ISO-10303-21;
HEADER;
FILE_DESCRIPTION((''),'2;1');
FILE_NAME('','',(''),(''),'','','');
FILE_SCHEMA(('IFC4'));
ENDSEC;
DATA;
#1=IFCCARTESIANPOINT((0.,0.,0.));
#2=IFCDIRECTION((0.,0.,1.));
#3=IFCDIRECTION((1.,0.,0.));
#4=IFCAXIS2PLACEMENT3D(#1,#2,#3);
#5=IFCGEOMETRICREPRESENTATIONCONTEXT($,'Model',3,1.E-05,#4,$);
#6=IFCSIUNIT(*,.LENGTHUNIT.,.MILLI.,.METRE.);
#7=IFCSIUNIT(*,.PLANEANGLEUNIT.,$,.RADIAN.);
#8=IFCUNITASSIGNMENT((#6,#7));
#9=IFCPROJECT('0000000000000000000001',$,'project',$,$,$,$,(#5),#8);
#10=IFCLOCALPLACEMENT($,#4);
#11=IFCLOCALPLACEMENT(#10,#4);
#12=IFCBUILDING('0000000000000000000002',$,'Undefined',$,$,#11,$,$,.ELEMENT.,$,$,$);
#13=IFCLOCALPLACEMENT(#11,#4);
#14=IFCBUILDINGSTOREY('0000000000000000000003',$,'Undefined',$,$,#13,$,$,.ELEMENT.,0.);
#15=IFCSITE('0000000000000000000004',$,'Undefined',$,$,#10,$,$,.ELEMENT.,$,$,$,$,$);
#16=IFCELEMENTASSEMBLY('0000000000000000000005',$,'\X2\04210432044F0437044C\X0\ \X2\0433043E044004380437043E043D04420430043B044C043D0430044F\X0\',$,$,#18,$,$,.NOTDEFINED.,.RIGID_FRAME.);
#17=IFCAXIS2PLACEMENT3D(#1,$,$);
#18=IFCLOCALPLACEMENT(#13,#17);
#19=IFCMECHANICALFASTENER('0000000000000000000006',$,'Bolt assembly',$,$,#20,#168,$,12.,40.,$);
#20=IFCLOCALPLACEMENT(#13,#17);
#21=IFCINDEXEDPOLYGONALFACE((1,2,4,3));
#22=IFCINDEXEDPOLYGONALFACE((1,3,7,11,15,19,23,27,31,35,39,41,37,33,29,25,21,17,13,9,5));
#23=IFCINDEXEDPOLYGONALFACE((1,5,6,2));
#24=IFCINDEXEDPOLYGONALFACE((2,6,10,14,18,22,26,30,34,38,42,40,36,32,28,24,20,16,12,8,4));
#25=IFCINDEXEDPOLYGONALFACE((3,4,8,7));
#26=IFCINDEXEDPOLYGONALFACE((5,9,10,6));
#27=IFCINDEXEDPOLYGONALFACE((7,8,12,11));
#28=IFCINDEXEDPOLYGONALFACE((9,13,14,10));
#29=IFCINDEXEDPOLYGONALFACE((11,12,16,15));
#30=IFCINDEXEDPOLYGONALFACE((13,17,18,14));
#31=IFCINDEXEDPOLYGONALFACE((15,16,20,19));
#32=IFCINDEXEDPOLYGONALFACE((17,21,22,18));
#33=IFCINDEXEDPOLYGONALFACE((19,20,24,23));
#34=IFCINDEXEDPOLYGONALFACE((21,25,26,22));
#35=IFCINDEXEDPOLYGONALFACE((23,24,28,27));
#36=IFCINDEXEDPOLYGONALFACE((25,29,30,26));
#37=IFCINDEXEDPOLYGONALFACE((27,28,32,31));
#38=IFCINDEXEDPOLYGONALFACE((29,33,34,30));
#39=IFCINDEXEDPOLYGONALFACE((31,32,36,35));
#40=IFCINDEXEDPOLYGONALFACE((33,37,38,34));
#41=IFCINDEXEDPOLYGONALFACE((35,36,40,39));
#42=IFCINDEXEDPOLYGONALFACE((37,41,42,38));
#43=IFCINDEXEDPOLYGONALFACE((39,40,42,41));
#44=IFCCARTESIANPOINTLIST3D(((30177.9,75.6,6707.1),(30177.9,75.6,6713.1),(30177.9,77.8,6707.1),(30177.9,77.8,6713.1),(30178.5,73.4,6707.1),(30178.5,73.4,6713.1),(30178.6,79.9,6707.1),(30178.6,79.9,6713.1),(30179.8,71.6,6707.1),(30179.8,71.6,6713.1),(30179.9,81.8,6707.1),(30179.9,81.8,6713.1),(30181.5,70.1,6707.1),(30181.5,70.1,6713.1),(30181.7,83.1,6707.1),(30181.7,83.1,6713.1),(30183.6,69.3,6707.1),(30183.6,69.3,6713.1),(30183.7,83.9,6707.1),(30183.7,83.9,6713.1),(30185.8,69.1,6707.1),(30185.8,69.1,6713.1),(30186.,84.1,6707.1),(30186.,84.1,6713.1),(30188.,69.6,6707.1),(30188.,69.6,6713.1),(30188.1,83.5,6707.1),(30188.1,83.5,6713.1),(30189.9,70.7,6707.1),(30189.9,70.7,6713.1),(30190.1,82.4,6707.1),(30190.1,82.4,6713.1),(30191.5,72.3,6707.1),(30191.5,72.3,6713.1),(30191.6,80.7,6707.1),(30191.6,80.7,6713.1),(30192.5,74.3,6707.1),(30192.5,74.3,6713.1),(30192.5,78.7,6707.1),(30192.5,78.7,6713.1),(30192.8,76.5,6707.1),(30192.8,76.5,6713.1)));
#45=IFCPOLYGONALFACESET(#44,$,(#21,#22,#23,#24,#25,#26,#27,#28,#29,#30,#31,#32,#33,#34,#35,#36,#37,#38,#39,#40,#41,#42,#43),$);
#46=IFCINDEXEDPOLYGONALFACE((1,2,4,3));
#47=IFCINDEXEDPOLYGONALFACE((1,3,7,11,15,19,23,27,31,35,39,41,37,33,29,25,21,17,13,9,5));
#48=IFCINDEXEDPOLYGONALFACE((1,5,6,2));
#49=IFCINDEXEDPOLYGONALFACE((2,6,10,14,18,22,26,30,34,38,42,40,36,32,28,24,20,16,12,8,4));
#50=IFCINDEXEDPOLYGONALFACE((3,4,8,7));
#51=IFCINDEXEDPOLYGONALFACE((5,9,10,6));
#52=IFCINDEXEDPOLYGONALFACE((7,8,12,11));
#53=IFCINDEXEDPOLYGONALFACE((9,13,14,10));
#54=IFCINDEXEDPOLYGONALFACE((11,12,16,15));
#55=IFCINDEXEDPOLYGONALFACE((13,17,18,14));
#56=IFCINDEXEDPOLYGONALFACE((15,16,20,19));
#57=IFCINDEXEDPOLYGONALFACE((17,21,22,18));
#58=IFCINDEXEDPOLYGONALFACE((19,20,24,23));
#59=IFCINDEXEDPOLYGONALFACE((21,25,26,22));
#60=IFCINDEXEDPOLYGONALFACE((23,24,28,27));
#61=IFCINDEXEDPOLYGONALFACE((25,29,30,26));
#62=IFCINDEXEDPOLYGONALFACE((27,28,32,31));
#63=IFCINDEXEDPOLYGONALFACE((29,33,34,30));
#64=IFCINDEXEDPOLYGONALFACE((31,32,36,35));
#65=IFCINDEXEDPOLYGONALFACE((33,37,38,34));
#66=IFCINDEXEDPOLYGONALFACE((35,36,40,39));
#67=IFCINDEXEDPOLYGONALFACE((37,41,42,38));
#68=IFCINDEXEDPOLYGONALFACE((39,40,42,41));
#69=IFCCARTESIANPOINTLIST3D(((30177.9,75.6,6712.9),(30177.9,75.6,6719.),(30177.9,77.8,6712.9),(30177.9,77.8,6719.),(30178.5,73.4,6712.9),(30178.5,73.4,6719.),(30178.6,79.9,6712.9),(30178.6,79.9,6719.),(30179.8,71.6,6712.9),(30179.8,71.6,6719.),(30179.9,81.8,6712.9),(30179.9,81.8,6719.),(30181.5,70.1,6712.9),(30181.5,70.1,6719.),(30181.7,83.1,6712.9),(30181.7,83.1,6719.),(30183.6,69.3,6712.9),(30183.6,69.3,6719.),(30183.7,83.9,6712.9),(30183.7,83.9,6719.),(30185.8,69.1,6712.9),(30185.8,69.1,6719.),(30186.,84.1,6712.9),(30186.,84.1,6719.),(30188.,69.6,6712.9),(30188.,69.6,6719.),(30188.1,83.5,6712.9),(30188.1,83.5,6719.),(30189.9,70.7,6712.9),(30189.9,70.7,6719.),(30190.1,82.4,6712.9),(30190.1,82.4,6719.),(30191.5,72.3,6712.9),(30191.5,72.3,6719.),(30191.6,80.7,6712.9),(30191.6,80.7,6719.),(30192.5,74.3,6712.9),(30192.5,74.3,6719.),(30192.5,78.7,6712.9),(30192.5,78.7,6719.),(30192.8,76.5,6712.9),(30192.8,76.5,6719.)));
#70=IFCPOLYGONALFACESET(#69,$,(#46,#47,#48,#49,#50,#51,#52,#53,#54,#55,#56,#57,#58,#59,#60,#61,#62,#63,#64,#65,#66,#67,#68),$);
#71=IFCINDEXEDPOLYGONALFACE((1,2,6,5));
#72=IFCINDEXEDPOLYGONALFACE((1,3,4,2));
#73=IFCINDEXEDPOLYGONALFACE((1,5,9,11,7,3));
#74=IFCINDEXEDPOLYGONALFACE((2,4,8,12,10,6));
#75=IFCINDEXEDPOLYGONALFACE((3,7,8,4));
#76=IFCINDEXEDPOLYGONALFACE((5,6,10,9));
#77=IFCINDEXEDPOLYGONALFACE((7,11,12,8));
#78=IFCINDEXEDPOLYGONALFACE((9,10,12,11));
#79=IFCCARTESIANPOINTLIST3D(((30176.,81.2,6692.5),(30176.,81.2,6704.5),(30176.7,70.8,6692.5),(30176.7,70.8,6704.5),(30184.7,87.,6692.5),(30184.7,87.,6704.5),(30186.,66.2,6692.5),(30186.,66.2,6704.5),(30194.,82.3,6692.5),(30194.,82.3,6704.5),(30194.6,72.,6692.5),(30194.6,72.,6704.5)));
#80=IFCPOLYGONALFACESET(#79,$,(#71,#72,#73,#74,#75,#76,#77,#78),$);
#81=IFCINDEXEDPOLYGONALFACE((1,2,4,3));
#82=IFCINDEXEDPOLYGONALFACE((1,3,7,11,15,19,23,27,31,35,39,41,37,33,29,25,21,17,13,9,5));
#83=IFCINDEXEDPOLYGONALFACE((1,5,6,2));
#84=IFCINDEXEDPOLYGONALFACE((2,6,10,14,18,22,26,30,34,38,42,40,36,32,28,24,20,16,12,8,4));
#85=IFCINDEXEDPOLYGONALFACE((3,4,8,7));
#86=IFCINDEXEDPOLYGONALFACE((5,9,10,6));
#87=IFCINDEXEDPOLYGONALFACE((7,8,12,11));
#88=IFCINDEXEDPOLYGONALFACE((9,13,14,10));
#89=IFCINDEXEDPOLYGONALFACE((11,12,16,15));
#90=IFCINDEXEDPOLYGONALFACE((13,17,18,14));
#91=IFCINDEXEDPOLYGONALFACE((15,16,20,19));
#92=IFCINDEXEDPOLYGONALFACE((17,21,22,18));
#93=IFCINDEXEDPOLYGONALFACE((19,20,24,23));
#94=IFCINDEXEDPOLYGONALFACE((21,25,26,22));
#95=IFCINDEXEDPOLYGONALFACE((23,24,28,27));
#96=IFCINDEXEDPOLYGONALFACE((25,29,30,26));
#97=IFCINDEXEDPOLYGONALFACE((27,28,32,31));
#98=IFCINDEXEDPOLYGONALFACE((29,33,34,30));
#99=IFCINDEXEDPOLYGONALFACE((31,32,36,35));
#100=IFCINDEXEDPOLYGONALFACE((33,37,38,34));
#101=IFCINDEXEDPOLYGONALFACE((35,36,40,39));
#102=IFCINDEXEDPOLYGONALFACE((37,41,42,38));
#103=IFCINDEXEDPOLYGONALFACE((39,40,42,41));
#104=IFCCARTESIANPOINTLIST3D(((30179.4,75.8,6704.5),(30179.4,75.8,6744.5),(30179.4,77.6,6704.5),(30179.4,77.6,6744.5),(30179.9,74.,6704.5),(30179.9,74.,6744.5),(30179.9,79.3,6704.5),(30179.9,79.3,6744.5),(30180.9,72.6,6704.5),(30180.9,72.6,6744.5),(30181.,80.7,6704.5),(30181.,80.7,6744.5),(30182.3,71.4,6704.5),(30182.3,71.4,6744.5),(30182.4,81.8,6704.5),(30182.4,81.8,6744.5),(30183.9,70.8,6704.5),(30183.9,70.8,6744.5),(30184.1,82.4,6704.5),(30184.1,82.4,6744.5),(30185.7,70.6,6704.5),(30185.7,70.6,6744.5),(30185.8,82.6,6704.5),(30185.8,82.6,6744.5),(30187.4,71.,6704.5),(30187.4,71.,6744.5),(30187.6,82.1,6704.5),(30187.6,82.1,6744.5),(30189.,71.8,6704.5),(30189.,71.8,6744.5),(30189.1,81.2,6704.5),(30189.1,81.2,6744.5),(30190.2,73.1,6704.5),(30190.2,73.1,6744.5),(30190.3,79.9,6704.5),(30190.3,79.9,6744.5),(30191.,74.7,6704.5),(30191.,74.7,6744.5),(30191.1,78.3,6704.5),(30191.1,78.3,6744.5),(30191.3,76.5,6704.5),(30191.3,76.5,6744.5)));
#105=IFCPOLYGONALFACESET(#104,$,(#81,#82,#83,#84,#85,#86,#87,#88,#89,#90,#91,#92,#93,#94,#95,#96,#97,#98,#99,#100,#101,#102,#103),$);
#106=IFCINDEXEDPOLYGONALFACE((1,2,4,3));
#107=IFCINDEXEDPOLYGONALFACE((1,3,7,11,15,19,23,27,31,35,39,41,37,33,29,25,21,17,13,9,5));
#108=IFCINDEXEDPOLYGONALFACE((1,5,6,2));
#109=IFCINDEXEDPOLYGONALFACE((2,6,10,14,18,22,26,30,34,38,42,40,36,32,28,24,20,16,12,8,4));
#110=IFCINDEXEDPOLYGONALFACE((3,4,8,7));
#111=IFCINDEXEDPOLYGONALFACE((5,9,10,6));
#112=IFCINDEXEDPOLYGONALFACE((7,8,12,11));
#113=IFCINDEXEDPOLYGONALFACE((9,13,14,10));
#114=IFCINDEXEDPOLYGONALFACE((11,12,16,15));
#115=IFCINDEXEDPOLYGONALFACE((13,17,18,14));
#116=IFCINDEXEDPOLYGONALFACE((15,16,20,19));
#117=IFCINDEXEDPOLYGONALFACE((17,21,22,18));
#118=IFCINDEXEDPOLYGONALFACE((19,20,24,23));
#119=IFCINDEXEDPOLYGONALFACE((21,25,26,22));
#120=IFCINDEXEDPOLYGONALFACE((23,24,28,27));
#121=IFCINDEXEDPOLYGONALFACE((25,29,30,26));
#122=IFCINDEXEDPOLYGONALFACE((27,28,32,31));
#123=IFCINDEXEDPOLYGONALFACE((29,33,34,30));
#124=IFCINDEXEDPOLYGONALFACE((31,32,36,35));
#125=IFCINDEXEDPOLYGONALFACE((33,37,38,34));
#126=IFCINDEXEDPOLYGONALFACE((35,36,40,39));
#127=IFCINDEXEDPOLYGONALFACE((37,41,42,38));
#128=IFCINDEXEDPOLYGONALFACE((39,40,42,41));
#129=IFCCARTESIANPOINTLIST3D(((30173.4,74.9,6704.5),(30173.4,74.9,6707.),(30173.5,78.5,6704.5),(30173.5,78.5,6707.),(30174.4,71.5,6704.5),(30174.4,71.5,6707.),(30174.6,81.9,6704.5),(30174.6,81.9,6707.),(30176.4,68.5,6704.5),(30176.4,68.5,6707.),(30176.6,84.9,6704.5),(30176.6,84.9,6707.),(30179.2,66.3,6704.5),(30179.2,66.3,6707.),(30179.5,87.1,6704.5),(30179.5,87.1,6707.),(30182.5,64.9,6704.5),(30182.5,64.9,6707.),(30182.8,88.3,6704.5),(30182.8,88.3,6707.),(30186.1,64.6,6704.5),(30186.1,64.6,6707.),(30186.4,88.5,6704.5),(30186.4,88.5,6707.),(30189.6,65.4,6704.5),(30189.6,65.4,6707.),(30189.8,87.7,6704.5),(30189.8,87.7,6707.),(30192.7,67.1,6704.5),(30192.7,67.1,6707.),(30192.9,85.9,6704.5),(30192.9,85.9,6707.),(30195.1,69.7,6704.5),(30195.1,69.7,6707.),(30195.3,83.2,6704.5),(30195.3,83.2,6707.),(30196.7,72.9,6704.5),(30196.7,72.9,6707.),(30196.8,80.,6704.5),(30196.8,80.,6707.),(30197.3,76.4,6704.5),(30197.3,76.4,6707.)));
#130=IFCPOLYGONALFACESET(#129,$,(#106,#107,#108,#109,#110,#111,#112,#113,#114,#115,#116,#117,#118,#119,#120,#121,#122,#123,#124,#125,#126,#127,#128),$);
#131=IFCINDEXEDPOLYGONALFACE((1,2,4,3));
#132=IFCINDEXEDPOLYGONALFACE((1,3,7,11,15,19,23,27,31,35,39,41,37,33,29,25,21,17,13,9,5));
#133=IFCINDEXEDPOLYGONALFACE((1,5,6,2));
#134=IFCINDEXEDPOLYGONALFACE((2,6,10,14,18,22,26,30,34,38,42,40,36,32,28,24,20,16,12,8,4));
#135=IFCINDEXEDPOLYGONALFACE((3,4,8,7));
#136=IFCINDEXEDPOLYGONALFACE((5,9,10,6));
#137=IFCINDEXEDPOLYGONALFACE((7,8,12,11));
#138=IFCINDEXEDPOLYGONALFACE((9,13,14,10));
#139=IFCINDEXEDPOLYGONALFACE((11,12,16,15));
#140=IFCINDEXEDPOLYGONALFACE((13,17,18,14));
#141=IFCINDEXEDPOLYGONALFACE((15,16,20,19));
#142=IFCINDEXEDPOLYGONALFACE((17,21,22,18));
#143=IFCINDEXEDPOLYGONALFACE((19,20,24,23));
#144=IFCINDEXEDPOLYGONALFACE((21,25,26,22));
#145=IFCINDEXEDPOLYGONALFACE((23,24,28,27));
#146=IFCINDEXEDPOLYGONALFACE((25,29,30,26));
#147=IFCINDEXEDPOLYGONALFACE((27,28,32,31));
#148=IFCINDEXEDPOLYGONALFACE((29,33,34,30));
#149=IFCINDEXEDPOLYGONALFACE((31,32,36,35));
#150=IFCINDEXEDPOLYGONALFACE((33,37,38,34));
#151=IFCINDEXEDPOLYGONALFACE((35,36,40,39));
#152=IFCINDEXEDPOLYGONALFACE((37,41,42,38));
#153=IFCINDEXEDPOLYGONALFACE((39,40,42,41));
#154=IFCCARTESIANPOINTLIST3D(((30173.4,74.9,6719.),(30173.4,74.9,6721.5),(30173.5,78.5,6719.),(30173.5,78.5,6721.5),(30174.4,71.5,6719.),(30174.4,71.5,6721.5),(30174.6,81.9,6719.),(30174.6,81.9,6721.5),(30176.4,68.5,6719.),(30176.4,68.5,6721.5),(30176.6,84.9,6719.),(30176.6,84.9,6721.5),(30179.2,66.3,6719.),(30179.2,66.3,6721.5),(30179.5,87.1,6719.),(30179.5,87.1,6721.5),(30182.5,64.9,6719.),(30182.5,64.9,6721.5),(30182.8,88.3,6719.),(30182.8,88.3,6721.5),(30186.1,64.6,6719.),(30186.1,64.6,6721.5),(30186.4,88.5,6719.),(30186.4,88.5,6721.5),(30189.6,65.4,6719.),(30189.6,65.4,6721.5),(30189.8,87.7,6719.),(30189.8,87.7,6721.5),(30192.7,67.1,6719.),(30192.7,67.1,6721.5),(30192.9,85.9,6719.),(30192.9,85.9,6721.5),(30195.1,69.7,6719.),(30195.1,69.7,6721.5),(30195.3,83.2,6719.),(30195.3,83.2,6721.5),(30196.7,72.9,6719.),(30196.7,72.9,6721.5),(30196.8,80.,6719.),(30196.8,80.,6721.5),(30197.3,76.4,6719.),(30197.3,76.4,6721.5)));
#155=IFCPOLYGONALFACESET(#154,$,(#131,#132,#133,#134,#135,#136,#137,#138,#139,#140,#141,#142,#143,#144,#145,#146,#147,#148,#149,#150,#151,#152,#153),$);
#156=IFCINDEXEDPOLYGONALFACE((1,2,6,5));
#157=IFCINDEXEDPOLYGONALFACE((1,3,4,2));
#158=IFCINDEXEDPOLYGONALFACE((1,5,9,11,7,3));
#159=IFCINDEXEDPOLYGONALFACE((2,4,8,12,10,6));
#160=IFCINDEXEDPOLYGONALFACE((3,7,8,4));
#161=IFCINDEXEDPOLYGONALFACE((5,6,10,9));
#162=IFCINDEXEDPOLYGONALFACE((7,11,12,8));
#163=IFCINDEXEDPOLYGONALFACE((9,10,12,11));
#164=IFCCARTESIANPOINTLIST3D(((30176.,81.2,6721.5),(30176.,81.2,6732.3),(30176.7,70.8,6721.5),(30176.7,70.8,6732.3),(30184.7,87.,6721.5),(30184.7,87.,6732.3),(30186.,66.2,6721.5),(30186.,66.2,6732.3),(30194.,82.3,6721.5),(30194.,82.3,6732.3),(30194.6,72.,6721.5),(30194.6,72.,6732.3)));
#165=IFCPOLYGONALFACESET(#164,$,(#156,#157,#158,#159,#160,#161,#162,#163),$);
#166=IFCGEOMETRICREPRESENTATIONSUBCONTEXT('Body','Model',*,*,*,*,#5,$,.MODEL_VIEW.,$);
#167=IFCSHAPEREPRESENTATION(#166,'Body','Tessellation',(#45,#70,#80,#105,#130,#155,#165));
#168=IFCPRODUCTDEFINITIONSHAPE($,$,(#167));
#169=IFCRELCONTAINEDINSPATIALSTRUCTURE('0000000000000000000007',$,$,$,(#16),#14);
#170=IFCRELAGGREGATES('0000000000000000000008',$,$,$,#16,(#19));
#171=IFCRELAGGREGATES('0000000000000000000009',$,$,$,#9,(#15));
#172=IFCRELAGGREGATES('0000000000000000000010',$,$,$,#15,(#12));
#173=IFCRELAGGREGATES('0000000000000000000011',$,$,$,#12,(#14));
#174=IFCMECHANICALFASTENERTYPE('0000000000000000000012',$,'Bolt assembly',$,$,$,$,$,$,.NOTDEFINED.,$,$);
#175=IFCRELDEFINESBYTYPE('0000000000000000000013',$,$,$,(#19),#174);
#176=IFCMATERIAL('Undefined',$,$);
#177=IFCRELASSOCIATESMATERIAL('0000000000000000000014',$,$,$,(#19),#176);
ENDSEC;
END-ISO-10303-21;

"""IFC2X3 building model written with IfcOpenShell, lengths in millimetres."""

from ifc_helpers import new_model, si_unit, frame, origin_with_axes, origin_2d_with_axis, place, context, subcontext, project, spatial, polyline, circle, outline, extrude, source, transform, mapped, material, type_object, element, aggregate, save


model = new_model("IFC2X3")

# Units and contexts
model_context = context("Model", 3, precision=1e-05, world=origin_with_axes())
body_context = subcontext(model_context, "Body", "Model", "MODEL_VIEW")
ifc_project = project(units=[si_unit("LENGTHUNIT", "METRE", prefix="MILLI"), si_unit("PLANEANGLEUNIT", "RADIAN")], contexts=[model_context])

# Site, building, storey
site_placement = place(None, origin_with_axes())
site = spatial("IfcSite", under=ifc_project, at=site_placement, Name="Undefined", CompositionType="ELEMENT")
building_placement = place(site_placement, origin_with_axes())
building = spatial("IfcBuilding", under=site, at=building_placement, Name="Undefined", CompositionType="ELEMENT")
storey_placement = place(building_placement, origin_with_axes())
storey = spatial("IfcBuildingStorey", under=building, at=storey_placement, Name="Undefined", CompositionType="ELEMENT", Elevation=0.0)

# Element assembly
assembly_1_placement = place(storey_placement, origin_with_axes())
assembly_1 = element("IfcElementAssembly", 1, at=assembly_1_placement, inside=storey, Name="Связь горизонтальная", AssemblyPlace="NOTDEFINED", PredefinedType="RIGID_FRAME")

# Mechanical fastener
ifc_material_1 = material(Name="Undefined")
mechanical_fastener_type = type_object("IfcMechanicalFastenerType", Name="Bolt assembly")
shared_shape_1 = source(origin_with_axes(), body_context, "Body", "SweptSolid", [
    extrude(circle(Radius=7.5, at=origin_2d_with_axis()), frame((0.0, 0.1, 0.0), z_axis=(0.0, 1.0, 0.0), x_axis=(1.0, 0.0, 0.0)), (0.0, 0.0, 1.0), 6.0),
    extrude(circle(Radius=7.5, at=origin_2d_with_axis()), frame((0.0, 5.9, 0.0), z_axis=(0.0, 1.0, 0.0), x_axis=(1.0, 0.0, 0.0)), (0.0, 0.0, 1.0), 6.1),
    extrude(outline(polyline([(10.4, 0.0), (5.2, 9.0), (-5.2, 9.0), (-10.4, 0.0), (-5.2, -9.0), (5.2, -9.0), (10.4, 0.0)])), frame((0.0, -14.5, 0.0), z_axis=(0.0, 1.0, 0.0), x_axis=(1.0, 0.0, 0.0)), (0.0, 0.0, 1.0), 12.0),
    extrude(circle(Radius=6.0, at=origin_2d_with_axis()), frame((0.0, -2.5, 0.0), z_axis=(0.0, 1.0, 0.0), x_axis=(1.0, 0.0, 0.0)), (0.0, 0.0, 1.0), 40.0),
    extrude(circle(Radius=12.0, at=origin_2d_with_axis()), frame((0.0, -2.5, 0.0), z_axis=(0.0, 1.0, 0.0), x_axis=(1.0, 0.0, 0.0)), (0.0, 0.0, 1.0), 2.5),
    extrude(circle(Radius=12.0, at=origin_2d_with_axis()), frame((0.0, 12.0, 0.0), z_axis=(0.0, 1.0, 0.0), x_axis=(1.0, 0.0, 0.0)), (0.0, 0.0, 1.0), 2.5),
    extrude(outline(polyline([(10.4, 0.0), (5.2, 9.0), (-5.2, 9.0), (-10.4, 0.0), (-5.2, -9.0), (5.2, -9.0), (10.4, 0.0)])), frame((0.0, 14.5, 0.0), z_axis=(0.0, 1.0, 0.0), x_axis=(1.0, 0.0, 0.0)), (0.0, 0.0, 1.0), 10.8),
])
mechanical_fastener_1_placement = place(assembly_1_placement, frame((30185.3, 76.6, 6707.0), z_axis=(0.552695, -0.833383, 0.0), x_axis=(0.833383, 0.552695, 0.0)))
mechanical_fastener_1 = element("IfcMechanicalFastener", 2, at=mechanical_fastener_1_placement, type_object=mechanical_fastener_type, material=ifc_material_1, Name="Bolt assembly", NominalDiameter=12.0, NominalLength=40.0, context=body_context, shape_type="MappedRepresentation", body=[
    mapped(shared_shape_1, transform((0.0, 0.0, 0.0))),
])
aggregate(assembly_1, [mechanical_fastener_1])

save(model, "model.ifc")
